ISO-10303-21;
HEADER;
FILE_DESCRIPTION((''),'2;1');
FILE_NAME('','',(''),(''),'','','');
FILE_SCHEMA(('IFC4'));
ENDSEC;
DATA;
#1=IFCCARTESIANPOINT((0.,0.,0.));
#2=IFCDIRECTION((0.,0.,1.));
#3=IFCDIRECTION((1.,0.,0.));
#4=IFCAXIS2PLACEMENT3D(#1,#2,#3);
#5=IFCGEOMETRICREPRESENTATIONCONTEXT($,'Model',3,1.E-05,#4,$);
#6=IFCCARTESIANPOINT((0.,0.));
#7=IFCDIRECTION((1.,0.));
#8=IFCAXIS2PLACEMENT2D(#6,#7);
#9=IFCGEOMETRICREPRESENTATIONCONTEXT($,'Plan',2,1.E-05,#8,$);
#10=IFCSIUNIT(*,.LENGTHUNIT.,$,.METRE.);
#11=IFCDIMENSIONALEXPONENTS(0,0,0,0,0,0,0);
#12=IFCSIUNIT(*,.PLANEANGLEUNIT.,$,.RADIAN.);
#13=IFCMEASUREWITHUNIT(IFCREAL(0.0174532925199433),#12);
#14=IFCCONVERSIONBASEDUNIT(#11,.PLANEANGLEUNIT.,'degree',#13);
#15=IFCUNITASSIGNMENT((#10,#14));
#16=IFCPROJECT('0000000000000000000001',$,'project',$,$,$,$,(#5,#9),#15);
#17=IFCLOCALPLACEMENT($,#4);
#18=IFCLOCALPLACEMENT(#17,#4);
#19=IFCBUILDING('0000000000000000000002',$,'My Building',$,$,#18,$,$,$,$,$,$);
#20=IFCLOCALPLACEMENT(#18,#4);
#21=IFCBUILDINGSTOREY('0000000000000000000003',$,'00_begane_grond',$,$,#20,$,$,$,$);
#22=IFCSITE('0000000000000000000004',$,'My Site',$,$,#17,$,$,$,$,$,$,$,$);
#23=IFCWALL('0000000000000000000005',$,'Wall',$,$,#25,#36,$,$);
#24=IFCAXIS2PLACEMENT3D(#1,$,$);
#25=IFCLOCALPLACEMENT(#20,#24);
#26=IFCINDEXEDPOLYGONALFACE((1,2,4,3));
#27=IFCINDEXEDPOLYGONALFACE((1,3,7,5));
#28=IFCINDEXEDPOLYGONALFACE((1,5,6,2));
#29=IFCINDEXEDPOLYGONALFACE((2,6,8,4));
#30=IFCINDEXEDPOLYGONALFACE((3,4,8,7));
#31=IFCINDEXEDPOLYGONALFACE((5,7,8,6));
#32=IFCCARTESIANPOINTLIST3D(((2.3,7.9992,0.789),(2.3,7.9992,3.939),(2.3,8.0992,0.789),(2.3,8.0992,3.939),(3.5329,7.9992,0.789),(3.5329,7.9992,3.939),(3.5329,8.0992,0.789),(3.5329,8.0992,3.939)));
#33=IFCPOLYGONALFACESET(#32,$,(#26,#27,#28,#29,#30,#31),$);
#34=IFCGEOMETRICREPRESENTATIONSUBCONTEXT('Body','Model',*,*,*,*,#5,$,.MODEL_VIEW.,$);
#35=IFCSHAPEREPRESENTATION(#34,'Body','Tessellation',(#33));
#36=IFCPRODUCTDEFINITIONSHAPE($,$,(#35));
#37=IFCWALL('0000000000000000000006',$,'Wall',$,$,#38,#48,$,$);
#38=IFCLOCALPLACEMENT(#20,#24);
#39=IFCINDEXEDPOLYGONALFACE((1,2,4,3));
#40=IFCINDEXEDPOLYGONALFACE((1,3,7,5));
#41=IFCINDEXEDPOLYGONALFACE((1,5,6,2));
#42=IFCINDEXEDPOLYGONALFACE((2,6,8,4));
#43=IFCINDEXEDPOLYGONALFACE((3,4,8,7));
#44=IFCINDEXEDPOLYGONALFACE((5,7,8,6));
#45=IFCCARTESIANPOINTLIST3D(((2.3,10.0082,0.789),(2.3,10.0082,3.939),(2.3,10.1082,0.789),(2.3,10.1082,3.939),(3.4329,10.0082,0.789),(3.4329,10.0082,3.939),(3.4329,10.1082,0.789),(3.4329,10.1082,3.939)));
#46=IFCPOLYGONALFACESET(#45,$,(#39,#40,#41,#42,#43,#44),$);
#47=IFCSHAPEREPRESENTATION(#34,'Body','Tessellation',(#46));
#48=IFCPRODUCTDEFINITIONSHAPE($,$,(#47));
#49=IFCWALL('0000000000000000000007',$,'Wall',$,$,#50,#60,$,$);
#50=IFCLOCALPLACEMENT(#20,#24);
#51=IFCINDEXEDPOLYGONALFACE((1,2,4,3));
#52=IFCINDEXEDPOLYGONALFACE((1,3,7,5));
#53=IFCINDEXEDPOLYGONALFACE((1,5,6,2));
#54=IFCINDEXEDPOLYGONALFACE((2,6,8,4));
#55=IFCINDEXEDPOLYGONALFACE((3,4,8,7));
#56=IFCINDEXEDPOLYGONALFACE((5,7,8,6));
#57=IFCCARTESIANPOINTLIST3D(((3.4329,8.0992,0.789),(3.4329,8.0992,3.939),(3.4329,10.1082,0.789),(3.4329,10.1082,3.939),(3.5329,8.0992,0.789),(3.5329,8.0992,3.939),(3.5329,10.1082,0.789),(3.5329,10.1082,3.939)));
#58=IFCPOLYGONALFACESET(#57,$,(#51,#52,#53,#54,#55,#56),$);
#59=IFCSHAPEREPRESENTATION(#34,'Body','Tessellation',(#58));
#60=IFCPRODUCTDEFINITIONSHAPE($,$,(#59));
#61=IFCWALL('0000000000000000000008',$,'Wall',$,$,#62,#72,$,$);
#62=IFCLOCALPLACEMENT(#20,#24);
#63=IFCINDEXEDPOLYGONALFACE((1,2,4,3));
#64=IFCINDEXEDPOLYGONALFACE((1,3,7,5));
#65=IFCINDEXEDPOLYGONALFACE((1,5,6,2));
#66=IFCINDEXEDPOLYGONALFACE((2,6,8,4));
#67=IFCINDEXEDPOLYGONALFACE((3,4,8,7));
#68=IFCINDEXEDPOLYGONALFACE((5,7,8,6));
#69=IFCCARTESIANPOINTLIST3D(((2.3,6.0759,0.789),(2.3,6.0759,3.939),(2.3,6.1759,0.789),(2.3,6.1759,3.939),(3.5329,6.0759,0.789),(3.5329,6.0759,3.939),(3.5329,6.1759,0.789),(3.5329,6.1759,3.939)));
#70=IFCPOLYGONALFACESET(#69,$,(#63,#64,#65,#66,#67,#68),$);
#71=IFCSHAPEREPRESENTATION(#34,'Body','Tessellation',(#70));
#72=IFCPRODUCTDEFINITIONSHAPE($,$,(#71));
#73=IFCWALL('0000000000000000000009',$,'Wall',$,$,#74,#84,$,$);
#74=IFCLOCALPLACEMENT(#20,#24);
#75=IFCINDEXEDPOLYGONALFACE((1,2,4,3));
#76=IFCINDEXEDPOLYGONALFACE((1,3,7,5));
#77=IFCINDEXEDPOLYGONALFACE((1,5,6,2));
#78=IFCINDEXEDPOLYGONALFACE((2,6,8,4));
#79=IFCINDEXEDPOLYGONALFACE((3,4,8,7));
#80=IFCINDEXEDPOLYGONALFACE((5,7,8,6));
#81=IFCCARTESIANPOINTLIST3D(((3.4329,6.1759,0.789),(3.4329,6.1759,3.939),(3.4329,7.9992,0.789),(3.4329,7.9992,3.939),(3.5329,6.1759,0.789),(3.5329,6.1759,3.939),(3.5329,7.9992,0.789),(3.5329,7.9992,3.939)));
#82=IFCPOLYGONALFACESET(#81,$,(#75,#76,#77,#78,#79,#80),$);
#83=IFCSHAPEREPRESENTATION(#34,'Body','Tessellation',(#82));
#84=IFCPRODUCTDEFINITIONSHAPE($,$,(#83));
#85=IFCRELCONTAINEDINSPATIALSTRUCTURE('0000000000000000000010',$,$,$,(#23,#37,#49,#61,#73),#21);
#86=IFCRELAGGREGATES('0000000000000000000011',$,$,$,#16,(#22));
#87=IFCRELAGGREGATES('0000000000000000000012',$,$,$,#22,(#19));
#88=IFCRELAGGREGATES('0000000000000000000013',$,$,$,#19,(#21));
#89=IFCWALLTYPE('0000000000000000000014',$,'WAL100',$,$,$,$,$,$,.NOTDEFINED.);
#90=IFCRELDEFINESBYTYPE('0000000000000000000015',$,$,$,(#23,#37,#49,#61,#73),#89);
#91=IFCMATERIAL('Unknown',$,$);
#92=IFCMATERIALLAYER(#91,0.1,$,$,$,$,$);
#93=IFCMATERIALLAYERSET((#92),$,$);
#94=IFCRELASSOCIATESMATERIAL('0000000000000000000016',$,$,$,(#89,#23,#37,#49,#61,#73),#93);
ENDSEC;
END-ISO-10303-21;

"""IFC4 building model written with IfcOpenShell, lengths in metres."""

from ifc_helpers import new_model, entity, si_unit, converted_unit, frame, origin_with_axes, origin_2d_with_axis, place, context, subcontext, project, spatial, indexed_curve, outline, extrude, clip, halfspace, material, layer, layer_set, layer_usage, type_object, element, save


model = new_model("IFC4")

# Units and contexts
model_context = context("Model", 3, precision=1e-05, world=origin_with_axes())
plan_context = context("Plan", 2, precision=1e-05, world=origin_2d_with_axis())
body_context = subcontext(model_context, "Body", "Model", "MODEL_VIEW")
ifc_project = project(units=[si_unit("LENGTHUNIT", "METRE"), converted_unit("PLANEANGLEUNIT", "degree", entity("IfcReal", 0.0174532925199433), si_unit("PLANEANGLEUNIT", "RADIAN"), dimensions=[0, 0, 0, 0, 0, 0, 0])], contexts=[model_context, plan_context])

# Site, building, storey
site_placement = place(None, origin_with_axes())
site = spatial("IfcSite", under=ifc_project, at=site_placement, Name="My Site")
building_placement = place(site_placement, origin_with_axes())
building = spatial("IfcBuilding", under=site, at=building_placement, Name="My Building")
storey_placement = place(building_placement, origin_with_axes())
storey = spatial("IfcBuildingStorey", under=building, at=storey_placement, Name="00_begane_grond")

# Shared definitions
ifc_material = material(Name="Unknown")

# Walls
ifc_layer_1 = layer(ifc_material, 0.1)
ifc_layer_set_1 = layer_set([ifc_layer_1])
wall_type = type_object("IfcWallType", Name="WAL100", PredefinedType="NOTDEFINED", material=ifc_layer_set_1)
ifc_layer_usage_1 = layer_usage(ifc_layer_set_1, "AXIS2", "POSITIVE", 0.0)
wall_1_placement = place(storey_placement, frame((2.3, 7.9992, 0.789), z_axis=(0.0, 0.0, 1.0), x_axis=(1.0, -0.000001, 0.0)))
element("IfcWall", 1, at=wall_1_placement, inside=storey, type_object=wall_type, material=ifc_layer_usage_1, Name="Wall", context=body_context, shape_type="Clipping", body=[
    clip(extrude(outline(indexed_curve([(0.0, 0.0), (0.0, 0.1), (1.2329, 0.1), (1.2329, 0.0), (0.0, 0.0)], self_intersect=False)), origin_with_axes(), (0.0, 0.0, 1.0), 3.939), halfspace(frame((0.0, 0.0, 3.15), z_axis=(0.0, 0.0, 1.0), x_axis=(-1.0, 0.0, 0.0)), False)),
])
ifc_layer_usage_2 = layer_usage(ifc_layer_set_1, "AXIS2", "POSITIVE", 0.0)
wall_2_placement = place(storey_placement, frame((2.3, 10.0082, 0.789), z_axis=(0.0, 0.0, 1.0), x_axis=(1.0, -0.000001, 0.0)))
element("IfcWall", 2, at=wall_2_placement, inside=storey, type_object=wall_type, material=ifc_layer_usage_2, Name="Wall", context=body_context, shape_type="Clipping", body=[
    clip(extrude(outline(indexed_curve([(0.0, 0.0), (0.0, 0.1), (1.1329, 0.1), (1.1329, 0.0), (0.0, 0.0)], self_intersect=False)), origin_with_axes(), (0.0, 0.0, 1.0), 3.939), halfspace(frame((0.0, 0.0, 3.15), z_axis=(0.0, 0.0, 1.0), x_axis=(-1.0, 0.0, 0.0)), False)),
])
ifc_layer_usage_3 = layer_usage(ifc_layer_set_1, "AXIS2", "POSITIVE", 0.0)
wall_3_placement = place(storey_placement, frame((3.5329, 8.0992, 0.789), z_axis=(0.0, 0.0, 1.0), x_axis=(0.000001, 1.0, 0.0)))
element("IfcWall", 3, at=wall_3_placement, inside=storey, type_object=wall_type, material=ifc_layer_usage_3, Name="Wall", context=body_context, shape_type="Clipping", body=[
    clip(extrude(outline(indexed_curve([(0.0, 0.0), (0.0, 0.1), (2.009, 0.1), (2.009, 0.0), (0.0, 0.0)], self_intersect=False)), origin_with_axes(), (0.0, 0.0, 1.0), 3.939), halfspace(frame((0.0, 0.0, 3.15), z_axis=(0.0, 0.0, 1.0), x_axis=(-1.0, 0.0, 0.0)), False)),
])
ifc_layer_usage_4 = layer_usage(ifc_layer_set_1, "AXIS2", "POSITIVE", 0.0)
wall_4_placement = place(storey_placement, frame((2.3, 6.0759, 0.789), z_axis=(0.0, 0.0, 1.0), x_axis=(1.0, -0.000001, 0.0)))
element("IfcWall", 4, at=wall_4_placement, inside=storey, type_object=wall_type, material=ifc_layer_usage_4, Name="Wall", context=body_context, shape_type="Clipping", body=[
    clip(extrude(outline(indexed_curve([(0.0, 0.0), (0.0, 0.1), (1.2329, 0.1), (1.2329, 0.0), (0.0, 0.0)], self_intersect=False)), origin_with_axes(), (0.0, 0.0, 1.0), 3.939), halfspace(frame((0.0, 0.0, 3.15), z_axis=(0.0, 0.0, 1.0), x_axis=(-1.0, 0.0, 0.0)), False)),
])
ifc_layer_usage_5 = layer_usage(ifc_layer_set_1, "AXIS2", "POSITIVE", 0.0)
wall_5_placement = place(storey_placement, frame((3.5329, 6.1759, 0.789), z_axis=(0.0, 0.0, 1.0), x_axis=(0.000001, 1.0, 0.0)))
element("IfcWall", 5, at=wall_5_placement, inside=storey, type_object=wall_type, material=ifc_layer_usage_5, Name="Wall", context=body_context, shape_type="Clipping", body=[
    clip(extrude(outline(indexed_curve([(0.0, 0.0), (0.0, 0.1), (1.8234, 0.1), (1.8234, 0.0), (0.0, 0.0)], self_intersect=False)), origin_with_axes(), (0.0, 0.0, 1.0), 3.939), halfspace(frame((0.0, 0.0, 3.15), z_axis=(0.0, 0.0, 1.0), x_axis=(-1.0, 0.0, 0.0)), False)),
])

save(model, "model.ifc")
